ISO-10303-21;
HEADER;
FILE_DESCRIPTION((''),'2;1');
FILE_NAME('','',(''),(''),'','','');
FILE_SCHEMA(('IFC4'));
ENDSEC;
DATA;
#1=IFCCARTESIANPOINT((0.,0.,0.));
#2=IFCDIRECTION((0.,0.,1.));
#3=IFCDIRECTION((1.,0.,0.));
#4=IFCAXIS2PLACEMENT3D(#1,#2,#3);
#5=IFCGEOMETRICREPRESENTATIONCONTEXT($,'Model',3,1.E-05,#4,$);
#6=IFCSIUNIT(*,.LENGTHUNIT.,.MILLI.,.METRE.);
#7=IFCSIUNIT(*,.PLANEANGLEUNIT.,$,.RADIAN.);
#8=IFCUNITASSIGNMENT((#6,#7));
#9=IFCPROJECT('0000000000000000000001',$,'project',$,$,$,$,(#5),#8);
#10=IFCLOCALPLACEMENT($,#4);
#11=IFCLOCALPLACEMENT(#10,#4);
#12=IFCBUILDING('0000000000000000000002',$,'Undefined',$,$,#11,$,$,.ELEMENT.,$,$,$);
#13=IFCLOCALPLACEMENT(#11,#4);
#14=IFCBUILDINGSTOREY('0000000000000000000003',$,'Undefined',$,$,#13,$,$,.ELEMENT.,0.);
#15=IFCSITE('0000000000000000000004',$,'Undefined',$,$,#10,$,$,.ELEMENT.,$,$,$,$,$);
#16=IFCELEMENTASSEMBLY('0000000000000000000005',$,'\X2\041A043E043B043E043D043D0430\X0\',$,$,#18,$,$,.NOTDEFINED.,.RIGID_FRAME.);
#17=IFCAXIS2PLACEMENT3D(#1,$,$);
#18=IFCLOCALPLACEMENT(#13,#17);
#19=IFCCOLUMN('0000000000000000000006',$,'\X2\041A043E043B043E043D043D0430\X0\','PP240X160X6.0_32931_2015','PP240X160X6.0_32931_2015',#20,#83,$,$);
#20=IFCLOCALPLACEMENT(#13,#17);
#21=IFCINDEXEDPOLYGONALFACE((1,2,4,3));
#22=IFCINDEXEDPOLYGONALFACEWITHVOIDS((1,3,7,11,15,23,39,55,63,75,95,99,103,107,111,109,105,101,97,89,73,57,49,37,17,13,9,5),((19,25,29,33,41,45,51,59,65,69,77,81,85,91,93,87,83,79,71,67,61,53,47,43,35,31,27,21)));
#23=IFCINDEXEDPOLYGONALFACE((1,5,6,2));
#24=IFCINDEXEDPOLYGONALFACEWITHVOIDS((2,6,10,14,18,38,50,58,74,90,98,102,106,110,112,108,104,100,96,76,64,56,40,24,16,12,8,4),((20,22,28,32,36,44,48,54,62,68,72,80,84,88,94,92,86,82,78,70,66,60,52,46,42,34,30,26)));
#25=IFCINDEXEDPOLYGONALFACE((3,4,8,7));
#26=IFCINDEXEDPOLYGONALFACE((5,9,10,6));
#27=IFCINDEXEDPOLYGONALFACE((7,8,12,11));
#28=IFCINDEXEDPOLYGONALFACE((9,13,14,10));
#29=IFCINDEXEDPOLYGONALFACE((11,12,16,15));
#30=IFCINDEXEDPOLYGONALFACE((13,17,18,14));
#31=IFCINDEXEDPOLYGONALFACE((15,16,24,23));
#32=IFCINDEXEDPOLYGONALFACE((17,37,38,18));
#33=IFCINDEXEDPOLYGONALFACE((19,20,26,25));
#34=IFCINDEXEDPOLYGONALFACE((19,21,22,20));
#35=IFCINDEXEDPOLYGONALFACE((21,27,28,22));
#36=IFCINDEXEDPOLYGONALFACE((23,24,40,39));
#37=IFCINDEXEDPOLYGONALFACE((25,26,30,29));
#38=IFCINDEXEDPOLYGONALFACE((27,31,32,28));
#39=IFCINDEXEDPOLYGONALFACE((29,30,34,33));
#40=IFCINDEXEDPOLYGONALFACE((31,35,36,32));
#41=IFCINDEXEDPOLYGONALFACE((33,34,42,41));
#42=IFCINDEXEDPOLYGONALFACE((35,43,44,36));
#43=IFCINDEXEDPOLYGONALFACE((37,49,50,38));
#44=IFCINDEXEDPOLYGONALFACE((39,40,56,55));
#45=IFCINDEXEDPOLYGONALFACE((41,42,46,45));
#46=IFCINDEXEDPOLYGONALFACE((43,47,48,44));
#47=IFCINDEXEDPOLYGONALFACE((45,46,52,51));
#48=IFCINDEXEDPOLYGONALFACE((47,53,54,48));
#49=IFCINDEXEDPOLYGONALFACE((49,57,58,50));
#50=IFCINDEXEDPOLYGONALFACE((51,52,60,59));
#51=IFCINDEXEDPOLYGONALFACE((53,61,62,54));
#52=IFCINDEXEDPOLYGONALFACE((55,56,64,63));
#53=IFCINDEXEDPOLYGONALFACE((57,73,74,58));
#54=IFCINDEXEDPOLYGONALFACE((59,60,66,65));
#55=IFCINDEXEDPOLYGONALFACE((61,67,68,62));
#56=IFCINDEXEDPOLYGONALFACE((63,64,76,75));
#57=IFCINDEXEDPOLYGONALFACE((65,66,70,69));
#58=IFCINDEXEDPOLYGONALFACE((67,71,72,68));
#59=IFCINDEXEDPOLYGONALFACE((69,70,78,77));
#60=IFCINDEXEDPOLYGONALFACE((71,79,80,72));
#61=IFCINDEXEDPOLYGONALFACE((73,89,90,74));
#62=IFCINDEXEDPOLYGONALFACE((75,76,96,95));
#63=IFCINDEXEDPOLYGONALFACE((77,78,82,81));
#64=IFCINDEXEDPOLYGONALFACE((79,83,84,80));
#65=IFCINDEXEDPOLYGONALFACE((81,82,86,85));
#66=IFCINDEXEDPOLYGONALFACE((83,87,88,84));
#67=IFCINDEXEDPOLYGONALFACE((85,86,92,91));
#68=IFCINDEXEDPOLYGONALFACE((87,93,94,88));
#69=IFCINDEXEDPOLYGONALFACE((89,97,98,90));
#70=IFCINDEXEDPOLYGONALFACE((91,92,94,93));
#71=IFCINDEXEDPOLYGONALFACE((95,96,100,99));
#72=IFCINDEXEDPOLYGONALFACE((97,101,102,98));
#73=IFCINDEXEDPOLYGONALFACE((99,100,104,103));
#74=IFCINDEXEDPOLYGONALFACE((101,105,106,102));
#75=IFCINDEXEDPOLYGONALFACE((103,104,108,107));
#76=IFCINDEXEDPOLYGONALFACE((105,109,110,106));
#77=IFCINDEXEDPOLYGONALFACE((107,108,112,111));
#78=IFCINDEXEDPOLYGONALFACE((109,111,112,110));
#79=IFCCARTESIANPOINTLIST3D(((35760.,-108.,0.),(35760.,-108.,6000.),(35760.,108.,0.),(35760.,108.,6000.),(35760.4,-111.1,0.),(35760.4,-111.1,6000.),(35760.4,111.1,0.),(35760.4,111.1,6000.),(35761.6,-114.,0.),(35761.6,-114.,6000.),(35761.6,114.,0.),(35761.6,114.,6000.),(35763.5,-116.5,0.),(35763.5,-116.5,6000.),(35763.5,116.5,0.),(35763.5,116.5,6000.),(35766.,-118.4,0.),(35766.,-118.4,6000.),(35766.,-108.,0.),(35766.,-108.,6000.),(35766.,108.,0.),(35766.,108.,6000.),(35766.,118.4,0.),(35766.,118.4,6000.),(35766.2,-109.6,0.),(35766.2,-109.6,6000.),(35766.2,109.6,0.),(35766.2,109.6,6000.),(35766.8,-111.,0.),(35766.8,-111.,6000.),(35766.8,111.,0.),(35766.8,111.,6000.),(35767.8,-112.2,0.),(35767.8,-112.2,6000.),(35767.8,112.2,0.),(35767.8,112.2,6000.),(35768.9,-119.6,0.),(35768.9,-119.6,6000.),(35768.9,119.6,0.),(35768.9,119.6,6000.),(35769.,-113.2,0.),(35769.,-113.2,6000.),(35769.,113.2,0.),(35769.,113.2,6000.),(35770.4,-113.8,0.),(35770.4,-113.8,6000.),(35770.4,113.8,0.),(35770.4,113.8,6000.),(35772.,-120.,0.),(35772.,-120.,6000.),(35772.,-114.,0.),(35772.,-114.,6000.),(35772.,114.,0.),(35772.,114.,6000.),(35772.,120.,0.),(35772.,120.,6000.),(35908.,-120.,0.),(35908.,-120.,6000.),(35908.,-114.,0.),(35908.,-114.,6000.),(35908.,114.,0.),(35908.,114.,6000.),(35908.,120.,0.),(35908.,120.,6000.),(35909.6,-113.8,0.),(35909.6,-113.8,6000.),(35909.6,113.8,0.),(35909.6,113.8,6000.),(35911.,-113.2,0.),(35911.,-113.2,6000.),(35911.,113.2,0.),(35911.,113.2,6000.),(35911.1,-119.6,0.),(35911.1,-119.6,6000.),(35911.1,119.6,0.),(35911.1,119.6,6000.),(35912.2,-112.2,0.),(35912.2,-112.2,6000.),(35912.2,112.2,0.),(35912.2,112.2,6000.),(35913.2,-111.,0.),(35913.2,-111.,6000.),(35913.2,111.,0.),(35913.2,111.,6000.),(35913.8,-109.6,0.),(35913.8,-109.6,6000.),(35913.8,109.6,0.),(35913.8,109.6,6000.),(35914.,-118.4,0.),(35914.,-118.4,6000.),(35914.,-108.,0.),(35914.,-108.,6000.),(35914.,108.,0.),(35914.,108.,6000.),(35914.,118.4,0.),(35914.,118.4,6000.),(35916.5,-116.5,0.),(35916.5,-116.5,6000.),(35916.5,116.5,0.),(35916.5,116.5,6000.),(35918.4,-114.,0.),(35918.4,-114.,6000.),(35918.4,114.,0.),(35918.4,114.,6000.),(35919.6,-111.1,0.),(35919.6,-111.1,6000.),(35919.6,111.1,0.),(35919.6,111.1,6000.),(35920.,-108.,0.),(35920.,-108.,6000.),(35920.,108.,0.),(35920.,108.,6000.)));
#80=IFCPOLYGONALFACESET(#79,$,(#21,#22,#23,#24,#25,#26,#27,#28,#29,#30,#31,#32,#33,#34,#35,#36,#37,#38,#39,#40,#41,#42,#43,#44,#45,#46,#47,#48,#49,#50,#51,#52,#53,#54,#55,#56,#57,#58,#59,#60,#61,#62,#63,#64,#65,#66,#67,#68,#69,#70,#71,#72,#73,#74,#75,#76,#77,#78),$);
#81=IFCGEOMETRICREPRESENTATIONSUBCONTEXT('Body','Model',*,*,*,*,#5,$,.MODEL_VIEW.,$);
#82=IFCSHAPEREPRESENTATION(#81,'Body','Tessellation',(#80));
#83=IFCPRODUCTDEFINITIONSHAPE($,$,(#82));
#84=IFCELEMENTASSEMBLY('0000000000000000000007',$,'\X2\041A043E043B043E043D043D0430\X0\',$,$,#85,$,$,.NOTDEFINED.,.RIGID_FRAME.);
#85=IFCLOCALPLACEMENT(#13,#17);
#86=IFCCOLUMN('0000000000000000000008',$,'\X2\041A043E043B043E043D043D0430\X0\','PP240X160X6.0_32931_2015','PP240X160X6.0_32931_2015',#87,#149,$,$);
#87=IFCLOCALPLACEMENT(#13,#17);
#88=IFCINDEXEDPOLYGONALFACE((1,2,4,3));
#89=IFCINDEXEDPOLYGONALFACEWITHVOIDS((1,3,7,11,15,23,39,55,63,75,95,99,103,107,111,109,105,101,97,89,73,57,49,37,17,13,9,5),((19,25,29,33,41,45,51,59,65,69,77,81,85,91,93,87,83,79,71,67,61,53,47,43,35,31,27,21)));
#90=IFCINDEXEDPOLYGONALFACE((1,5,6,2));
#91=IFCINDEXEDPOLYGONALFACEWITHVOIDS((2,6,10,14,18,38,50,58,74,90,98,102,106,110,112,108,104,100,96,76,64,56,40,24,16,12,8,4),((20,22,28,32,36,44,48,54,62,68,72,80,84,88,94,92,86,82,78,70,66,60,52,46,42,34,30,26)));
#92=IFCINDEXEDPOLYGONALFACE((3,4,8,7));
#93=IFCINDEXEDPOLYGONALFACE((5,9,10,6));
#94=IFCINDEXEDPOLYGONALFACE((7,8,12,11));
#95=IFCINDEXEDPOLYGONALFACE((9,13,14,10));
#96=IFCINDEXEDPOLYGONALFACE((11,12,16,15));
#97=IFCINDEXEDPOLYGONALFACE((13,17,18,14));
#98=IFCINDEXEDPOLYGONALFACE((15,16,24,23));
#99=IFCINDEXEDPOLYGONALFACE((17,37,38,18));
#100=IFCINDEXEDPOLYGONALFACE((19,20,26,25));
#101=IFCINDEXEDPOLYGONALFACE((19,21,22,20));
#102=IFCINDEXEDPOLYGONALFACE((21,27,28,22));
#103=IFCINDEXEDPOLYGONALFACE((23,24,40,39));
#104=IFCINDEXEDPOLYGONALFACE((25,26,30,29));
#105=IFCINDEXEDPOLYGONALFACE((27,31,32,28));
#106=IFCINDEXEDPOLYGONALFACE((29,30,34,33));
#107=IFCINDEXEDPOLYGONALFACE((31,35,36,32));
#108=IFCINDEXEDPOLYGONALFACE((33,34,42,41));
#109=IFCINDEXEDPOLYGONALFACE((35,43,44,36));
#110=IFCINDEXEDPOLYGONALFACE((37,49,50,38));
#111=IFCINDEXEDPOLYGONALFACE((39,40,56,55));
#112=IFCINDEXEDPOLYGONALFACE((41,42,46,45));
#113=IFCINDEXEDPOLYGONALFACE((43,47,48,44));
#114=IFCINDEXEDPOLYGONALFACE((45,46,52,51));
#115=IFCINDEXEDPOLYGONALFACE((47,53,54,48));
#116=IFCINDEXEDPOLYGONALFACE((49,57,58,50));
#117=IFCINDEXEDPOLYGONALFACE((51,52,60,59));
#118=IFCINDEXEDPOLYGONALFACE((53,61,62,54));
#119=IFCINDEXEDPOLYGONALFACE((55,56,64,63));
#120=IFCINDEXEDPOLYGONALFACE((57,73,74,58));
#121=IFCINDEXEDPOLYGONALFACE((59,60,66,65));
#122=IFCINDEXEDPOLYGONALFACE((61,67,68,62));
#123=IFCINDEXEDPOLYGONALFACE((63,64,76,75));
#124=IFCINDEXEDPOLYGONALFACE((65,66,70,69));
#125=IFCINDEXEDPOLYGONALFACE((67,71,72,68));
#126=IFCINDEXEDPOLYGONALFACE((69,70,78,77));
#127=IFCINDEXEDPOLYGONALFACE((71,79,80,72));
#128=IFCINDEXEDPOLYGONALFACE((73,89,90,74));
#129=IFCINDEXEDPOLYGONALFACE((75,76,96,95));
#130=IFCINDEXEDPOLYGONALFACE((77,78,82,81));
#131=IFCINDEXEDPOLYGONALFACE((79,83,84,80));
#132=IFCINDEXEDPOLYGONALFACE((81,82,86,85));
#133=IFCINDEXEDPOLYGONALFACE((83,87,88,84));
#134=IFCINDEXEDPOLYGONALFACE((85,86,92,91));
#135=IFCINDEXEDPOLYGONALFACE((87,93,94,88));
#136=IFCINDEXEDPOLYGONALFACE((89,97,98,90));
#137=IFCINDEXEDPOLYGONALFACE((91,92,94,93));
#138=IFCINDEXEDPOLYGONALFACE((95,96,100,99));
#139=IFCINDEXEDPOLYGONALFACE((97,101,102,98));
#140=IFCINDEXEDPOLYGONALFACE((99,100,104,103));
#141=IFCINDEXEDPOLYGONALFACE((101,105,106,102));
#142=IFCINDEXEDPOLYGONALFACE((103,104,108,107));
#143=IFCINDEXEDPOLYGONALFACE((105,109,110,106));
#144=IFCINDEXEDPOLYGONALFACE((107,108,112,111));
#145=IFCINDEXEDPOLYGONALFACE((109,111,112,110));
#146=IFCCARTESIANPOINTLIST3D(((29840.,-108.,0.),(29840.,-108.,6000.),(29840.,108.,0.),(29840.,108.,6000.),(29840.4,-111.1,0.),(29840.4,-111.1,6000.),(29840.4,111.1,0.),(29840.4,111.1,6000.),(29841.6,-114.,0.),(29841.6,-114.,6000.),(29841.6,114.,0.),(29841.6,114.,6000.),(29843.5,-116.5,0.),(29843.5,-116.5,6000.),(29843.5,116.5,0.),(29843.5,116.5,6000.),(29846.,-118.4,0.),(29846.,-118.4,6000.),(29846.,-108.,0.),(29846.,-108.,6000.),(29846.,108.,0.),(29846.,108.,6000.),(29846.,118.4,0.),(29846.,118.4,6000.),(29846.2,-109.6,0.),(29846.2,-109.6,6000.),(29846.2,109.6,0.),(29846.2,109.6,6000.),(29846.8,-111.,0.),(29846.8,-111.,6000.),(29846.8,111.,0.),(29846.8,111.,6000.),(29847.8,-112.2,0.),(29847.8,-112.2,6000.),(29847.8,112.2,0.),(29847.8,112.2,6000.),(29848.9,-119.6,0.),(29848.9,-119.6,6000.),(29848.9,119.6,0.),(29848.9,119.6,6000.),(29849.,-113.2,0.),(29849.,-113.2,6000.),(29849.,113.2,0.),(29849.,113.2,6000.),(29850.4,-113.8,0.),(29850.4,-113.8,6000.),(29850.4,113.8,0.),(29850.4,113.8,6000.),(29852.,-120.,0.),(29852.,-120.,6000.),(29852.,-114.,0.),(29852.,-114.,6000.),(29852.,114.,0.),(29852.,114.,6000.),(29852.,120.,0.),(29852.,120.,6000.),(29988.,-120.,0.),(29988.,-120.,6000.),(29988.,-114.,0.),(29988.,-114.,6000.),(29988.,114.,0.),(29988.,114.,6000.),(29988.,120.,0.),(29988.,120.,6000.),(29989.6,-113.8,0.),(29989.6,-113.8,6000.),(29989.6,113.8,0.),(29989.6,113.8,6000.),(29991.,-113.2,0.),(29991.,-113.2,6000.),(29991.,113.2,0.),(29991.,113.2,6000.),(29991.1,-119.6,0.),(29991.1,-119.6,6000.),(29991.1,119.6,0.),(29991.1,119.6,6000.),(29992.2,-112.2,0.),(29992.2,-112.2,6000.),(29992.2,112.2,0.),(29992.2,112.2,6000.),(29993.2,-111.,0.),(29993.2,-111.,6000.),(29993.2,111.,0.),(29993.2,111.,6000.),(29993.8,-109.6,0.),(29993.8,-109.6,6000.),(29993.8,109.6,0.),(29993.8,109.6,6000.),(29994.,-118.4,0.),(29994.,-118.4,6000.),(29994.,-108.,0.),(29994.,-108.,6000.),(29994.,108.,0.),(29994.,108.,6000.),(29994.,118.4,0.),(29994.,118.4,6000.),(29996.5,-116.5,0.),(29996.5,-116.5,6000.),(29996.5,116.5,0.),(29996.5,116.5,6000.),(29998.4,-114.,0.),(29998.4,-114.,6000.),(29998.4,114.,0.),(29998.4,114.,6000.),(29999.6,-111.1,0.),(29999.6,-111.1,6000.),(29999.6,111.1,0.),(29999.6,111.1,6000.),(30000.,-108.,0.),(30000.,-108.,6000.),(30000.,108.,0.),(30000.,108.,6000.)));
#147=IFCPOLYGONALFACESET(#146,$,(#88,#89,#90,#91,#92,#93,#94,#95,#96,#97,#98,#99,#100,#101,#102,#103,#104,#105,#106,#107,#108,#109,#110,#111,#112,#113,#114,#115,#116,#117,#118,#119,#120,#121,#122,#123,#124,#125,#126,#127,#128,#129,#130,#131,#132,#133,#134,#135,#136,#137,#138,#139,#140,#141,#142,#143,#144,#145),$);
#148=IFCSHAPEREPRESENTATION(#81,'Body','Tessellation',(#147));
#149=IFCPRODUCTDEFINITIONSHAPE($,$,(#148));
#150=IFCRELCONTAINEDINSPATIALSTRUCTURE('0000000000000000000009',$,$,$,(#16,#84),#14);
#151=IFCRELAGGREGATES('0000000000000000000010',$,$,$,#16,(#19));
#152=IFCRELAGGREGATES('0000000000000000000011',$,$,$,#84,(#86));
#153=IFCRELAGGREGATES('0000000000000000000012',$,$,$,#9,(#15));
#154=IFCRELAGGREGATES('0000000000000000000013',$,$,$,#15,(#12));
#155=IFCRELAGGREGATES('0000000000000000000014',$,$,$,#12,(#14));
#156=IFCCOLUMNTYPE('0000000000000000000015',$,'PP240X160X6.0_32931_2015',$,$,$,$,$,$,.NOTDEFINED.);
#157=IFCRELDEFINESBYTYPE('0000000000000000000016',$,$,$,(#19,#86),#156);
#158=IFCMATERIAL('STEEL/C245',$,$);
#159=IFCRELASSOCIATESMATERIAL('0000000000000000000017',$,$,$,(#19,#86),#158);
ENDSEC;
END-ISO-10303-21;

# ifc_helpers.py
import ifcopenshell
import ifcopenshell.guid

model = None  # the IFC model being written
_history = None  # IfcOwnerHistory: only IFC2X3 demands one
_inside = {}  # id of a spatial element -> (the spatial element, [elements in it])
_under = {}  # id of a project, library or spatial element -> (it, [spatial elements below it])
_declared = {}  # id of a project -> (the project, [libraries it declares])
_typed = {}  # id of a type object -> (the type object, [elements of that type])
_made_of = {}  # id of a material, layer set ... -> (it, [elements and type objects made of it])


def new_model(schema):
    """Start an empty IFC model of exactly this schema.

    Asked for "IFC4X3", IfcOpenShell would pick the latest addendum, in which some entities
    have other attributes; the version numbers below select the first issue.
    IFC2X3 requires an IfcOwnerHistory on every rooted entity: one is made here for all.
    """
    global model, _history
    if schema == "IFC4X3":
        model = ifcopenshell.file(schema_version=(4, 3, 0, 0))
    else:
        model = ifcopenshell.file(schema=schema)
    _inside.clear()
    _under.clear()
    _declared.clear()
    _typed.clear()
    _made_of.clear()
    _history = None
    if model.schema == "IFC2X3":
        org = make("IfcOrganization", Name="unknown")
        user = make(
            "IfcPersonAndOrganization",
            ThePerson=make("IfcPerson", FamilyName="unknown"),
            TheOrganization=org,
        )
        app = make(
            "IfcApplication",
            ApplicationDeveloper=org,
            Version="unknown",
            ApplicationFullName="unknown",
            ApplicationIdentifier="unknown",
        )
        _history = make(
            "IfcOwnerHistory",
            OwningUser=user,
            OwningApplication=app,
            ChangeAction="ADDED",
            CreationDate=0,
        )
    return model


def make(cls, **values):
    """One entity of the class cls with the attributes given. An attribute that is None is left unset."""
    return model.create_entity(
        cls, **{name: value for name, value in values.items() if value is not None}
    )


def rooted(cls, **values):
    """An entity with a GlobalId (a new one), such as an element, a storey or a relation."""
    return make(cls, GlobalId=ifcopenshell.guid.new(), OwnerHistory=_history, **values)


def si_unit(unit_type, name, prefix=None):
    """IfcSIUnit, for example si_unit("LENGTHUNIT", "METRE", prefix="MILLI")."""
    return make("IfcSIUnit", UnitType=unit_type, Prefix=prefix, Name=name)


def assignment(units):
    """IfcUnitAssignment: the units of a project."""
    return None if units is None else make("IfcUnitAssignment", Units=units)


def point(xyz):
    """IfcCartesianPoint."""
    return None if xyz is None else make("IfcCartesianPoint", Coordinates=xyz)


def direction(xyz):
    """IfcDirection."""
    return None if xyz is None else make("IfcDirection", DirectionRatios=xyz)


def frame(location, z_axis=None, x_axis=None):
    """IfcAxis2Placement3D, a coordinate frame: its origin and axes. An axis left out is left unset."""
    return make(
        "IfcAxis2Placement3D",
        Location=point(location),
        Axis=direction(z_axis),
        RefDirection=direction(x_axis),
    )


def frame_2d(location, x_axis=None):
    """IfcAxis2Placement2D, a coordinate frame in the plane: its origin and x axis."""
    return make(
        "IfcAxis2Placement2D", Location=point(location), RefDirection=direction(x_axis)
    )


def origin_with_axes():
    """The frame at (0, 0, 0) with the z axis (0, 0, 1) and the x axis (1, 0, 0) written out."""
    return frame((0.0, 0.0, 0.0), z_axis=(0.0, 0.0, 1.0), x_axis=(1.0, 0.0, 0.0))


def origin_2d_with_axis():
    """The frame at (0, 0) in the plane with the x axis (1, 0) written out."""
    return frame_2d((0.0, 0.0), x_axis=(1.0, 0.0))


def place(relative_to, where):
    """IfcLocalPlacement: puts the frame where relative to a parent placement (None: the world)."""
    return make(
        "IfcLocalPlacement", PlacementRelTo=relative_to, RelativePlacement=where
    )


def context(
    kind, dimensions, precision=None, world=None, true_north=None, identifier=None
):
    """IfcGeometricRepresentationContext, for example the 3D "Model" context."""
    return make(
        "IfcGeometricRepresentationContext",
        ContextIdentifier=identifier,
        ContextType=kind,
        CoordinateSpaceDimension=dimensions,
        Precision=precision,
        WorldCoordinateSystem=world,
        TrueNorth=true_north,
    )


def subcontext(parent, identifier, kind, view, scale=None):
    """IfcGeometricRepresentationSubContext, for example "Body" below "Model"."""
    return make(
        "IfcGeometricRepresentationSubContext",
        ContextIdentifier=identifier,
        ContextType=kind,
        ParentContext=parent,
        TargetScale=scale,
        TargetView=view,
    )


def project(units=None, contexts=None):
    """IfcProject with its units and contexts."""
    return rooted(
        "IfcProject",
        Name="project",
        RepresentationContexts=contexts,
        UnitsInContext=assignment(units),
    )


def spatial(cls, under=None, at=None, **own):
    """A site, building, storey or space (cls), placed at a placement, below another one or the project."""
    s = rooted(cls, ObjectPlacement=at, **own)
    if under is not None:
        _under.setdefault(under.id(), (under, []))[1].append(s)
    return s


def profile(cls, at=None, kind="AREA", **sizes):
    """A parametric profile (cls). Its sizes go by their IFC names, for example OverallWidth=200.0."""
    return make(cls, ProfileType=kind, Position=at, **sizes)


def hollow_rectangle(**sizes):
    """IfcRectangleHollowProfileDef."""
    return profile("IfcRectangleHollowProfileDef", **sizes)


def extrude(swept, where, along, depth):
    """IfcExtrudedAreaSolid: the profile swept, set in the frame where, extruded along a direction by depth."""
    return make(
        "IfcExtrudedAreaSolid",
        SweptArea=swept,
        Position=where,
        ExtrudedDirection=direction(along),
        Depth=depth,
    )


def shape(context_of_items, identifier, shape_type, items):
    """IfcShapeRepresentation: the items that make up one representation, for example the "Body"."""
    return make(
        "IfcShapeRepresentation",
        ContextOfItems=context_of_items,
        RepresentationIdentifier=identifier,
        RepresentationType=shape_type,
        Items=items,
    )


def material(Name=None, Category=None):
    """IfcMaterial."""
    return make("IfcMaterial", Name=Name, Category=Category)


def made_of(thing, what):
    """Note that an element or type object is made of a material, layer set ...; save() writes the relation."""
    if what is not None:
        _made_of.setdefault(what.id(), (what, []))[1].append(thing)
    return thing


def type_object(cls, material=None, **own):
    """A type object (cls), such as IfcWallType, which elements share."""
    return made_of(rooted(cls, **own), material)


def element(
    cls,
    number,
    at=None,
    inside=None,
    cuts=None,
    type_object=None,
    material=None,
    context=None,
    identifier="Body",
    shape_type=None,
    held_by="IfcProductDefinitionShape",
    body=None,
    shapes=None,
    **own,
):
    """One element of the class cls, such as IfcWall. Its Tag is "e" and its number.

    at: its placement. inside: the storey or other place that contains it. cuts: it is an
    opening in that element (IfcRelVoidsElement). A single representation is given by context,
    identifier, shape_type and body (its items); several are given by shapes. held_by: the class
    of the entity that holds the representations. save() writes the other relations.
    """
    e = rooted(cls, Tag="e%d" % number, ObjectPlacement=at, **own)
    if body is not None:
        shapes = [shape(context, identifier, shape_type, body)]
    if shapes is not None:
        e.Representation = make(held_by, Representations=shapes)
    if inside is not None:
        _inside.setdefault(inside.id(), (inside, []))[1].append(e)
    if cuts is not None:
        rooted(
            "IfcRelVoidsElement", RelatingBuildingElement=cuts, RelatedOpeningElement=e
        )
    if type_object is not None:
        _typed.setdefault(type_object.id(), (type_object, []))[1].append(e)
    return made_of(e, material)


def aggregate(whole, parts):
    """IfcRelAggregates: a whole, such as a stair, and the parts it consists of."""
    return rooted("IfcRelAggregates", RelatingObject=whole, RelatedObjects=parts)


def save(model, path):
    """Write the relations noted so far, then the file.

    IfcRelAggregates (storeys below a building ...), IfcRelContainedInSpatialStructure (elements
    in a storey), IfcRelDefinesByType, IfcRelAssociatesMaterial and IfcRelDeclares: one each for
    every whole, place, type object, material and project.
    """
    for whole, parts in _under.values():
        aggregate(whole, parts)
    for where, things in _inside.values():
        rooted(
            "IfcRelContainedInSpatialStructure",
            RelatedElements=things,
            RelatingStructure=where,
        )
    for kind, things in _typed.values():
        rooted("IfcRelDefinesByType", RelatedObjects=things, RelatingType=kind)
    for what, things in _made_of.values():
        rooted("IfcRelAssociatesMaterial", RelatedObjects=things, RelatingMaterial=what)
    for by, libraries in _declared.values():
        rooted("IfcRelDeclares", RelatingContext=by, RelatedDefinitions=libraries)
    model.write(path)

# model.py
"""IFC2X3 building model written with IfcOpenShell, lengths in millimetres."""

from ifc_helpers import new_model, si_unit, frame, origin_with_axes, origin_2d_with_axis, place, context, subcontext, project, spatial, hollow_rectangle, extrude, material, type_object, element, aggregate, save


model = new_model("IFC2X3")

# Units and contexts
model_context = context("Model", 3, precision=1e-05, world=origin_with_axes())
body_context = subcontext(model_context, "Body", "Model", "MODEL_VIEW")
ifc_project = project(units=[si_unit("LENGTHUNIT", "METRE", prefix="MILLI"), si_unit("PLANEANGLEUNIT", "RADIAN")], contexts=[model_context])

# Site, building, storey
site_placement = place(None, origin_with_axes())
site = spatial("IfcSite", under=ifc_project, at=site_placement, Name="Undefined", CompositionType="ELEMENT")
building_placement = place(site_placement, origin_with_axes())
building = spatial("IfcBuilding", under=site, at=building_placement, Name="Undefined", CompositionType="ELEMENT")
storey_placement = place(building_placement, origin_with_axes())
storey = spatial("IfcBuildingStorey", under=building, at=storey_placement, Name="Undefined", CompositionType="ELEMENT", Elevation=0.0)

# Element assemblies, columns
assembly_1_placement = place(storey_placement, origin_with_axes())
assembly_1 = element("IfcElementAssembly", 1, at=assembly_1_placement, inside=storey, Name="Колонна", AssemblyPlace="NOTDEFINED", PredefinedType="RIGID_FRAME")
ifc_material = material(Name="STEEL/C245")
column_type_1 = type_object("IfcColumnType", Name="PP240X160X6.0_32931_2015", PredefinedType="NOTDEFINED")
column_1_placement = place(assembly_1_placement, frame((35840.0, 0.0, 0.0), z_axis=(0.0, 0.0, 1.0), x_axis=(0.0, 1.0, 0.0)))
column_1 = element("IfcColumn", 2, at=column_1_placement, type_object=column_type_1, material=ifc_material, Name="Колонна", Description="PP240X160X6.0_32931_2015", ObjectType="PP240X160X6.0_32931_2015", context=body_context, shape_type="SweptSolid", body=[
    extrude(hollow_rectangle(XDim=160.0, YDim=240.0, WallThickness=6.0, InnerFilletRadius=6.0, OuterFilletRadius=12.0, at=origin_2d_with_axis()), frame((0.0, 0.0, 6000.0), z_axis=(0.0, 0.0, -1.0), x_axis=(0.0, 1.0, 0.0)), (0.0, 0.0, 1.0), 6000.0),
])
aggregate(assembly_1, [column_1])
assembly_2_placement = place(storey_placement, origin_with_axes())
assembly_2 = element("IfcElementAssembly", 3, at=assembly_2_placement, inside=storey, Name="Колонна", AssemblyPlace="NOTDEFINED", PredefinedType="RIGID_FRAME")
column_2_placement = place(assembly_2_placement, frame((29920.0, 0.0, 0.0), z_axis=(0.0, 0.0, 1.0), x_axis=(0.0, 1.0, 0.0)))
column_2 = element("IfcColumn", 4, at=column_2_placement, type_object=column_type_1, material=ifc_material, Name="Колонна", Description="PP240X160X6.0_32931_2015", ObjectType="PP240X160X6.0_32931_2015", context=body_context, shape_type="SweptSolid", body=[
    extrude(hollow_rectangle(XDim=160.0, YDim=240.0, WallThickness=6.0, InnerFilletRadius=6.0, OuterFilletRadius=12.0, at=origin_2d_with_axis()), frame((0.0, 0.0, 6000.0), z_axis=(0.0, 0.0, -1.0), x_axis=(0.0, 1.0, 0.0)), (0.0, 0.0, 1.0), 6000.0),
])
aggregate(assembly_2, [column_2])

save(model, "model.ifc")
